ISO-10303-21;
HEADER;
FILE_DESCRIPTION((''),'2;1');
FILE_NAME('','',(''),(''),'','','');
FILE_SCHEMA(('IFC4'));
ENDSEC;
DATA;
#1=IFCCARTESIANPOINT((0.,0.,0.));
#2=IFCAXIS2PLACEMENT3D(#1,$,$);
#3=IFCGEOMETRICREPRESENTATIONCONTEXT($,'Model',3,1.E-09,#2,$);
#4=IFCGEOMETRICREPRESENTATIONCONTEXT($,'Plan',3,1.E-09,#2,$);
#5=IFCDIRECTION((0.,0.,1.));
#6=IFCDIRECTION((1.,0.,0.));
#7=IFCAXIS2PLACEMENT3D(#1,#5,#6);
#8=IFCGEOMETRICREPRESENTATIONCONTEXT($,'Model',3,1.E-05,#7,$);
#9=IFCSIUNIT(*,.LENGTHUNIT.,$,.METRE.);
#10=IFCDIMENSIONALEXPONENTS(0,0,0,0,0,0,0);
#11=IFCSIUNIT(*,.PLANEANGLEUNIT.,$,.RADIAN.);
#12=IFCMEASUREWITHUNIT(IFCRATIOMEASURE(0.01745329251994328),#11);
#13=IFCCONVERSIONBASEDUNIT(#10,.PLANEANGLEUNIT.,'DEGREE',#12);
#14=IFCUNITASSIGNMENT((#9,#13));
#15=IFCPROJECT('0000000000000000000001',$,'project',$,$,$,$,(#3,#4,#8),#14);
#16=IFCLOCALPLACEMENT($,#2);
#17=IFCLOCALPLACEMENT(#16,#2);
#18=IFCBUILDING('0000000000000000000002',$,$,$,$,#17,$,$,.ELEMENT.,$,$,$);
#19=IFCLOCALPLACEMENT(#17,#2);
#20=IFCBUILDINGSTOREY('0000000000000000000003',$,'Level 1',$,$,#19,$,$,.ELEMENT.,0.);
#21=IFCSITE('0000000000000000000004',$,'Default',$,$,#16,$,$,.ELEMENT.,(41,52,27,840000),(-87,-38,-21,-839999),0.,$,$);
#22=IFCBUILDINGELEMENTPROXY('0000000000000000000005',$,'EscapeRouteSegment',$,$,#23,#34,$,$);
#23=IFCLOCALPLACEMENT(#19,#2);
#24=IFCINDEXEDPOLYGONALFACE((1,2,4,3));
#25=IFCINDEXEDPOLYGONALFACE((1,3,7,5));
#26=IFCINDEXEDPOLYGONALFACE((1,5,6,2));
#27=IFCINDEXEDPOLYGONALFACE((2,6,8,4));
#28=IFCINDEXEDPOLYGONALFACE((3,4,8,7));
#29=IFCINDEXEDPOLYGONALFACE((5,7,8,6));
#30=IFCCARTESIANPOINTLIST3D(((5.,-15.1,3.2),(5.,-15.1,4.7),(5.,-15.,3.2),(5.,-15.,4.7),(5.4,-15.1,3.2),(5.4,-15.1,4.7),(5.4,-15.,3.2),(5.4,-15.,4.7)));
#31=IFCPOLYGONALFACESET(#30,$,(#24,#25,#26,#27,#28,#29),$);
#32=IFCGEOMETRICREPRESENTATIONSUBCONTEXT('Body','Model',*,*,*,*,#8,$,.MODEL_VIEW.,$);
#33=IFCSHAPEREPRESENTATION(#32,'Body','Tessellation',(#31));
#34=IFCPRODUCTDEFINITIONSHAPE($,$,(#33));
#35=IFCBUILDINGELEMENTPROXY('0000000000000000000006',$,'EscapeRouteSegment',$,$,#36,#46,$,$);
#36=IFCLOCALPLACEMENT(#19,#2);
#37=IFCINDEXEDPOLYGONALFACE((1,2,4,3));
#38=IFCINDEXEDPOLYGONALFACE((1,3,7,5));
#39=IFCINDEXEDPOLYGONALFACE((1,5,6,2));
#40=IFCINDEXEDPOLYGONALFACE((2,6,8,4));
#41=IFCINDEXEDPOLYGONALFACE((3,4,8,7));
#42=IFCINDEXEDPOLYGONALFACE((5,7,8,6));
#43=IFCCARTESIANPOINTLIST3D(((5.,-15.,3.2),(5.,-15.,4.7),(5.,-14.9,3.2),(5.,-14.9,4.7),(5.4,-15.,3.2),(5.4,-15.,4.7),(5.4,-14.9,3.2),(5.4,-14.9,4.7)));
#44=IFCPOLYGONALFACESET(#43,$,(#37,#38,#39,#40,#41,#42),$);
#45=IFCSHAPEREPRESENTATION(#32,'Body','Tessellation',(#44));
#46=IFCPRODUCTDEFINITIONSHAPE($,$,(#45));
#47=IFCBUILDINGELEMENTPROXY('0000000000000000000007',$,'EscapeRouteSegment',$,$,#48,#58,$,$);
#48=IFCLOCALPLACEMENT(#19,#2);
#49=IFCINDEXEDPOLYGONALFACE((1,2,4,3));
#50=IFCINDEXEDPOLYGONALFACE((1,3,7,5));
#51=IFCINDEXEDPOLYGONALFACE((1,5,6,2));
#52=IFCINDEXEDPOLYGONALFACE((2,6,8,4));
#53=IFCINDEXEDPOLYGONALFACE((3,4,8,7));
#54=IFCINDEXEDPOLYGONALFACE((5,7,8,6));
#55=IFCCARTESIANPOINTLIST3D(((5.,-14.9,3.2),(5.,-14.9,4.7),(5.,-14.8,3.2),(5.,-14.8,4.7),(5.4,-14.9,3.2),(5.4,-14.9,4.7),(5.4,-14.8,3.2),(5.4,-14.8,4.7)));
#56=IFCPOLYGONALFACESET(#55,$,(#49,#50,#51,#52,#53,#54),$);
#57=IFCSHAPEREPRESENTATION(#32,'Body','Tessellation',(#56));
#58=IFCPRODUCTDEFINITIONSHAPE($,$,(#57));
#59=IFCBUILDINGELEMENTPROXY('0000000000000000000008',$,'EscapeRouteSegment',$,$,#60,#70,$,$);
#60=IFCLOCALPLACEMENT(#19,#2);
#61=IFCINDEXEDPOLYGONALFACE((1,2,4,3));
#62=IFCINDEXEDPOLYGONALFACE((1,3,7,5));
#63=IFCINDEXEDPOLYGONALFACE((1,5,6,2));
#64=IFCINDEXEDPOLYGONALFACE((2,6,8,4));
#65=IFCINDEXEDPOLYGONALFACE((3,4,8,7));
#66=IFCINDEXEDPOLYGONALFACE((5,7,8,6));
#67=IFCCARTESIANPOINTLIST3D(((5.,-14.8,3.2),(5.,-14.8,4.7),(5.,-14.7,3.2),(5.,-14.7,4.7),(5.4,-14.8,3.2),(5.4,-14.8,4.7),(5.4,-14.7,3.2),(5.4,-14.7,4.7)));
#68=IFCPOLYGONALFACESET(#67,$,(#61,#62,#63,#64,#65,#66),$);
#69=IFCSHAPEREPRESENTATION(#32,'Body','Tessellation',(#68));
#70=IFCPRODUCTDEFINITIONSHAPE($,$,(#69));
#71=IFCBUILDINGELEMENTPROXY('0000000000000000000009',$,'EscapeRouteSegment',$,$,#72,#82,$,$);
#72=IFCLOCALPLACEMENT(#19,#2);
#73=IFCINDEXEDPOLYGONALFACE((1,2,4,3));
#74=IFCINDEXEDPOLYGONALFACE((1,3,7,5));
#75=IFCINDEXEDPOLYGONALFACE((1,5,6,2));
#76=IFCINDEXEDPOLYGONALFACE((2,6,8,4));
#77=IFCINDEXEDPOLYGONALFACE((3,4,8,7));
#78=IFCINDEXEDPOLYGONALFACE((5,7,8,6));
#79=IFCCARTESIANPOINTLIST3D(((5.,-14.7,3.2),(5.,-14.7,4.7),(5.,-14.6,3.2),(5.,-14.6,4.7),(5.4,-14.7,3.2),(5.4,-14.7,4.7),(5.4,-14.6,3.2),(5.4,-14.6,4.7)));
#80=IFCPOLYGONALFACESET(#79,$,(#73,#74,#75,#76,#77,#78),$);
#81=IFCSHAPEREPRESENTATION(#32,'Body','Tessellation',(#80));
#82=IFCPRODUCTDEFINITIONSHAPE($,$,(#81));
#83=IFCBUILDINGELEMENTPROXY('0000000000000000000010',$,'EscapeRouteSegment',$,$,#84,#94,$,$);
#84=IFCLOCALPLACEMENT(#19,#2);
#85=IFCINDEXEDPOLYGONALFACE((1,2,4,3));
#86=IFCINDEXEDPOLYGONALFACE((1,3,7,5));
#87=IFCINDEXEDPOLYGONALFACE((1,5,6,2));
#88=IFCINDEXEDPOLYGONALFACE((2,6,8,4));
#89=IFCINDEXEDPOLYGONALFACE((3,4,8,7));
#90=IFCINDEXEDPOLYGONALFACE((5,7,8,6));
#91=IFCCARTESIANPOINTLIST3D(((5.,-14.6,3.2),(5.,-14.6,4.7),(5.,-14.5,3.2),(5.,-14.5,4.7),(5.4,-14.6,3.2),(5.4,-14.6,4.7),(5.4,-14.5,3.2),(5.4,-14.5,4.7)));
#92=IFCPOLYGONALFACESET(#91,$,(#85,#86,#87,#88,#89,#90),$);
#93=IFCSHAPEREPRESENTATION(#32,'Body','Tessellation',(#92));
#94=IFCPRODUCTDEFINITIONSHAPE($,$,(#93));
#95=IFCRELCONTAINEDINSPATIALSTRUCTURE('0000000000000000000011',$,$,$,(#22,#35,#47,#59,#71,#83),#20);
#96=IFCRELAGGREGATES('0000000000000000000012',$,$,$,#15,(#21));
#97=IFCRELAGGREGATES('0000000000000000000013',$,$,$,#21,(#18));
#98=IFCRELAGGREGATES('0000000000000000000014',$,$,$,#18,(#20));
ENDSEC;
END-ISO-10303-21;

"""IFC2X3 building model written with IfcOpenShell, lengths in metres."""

from ifc_helpers import new_model, entity, si_unit, converted_unit, frame, origin, origin_with_axes, place, context, subcontext, project, spatial, polyline, outline, extrude, element, save


model = new_model("IFC2X3")

# Units and contexts
model_context_1 = context("Model", 3, precision=1e-09, world=origin())
plan_context = context("Plan", 3, precision=1e-09, world=origin())
model_context_2 = context("Model", 3, precision=1e-05, world=origin_with_axes())
body_context = subcontext(model_context_2, "Body", "Model", "MODEL_VIEW")
ifc_project = project(units=[si_unit("LENGTHUNIT", "METRE"), converted_unit("PLANEANGLEUNIT", "DEGREE", entity("IfcRatioMeasure", 0.01745329251994328), si_unit("PLANEANGLEUNIT", "RADIAN"), dimensions=[0, 0, 0, 0, 0, 0, 0])], contexts=[model_context_1, plan_context, model_context_2])

# Site, building, storey
site_placement = place(None, origin())
site = spatial("IfcSite", under=ifc_project, at=site_placement, Name="Default", CompositionType="ELEMENT", RefLatitude=(41, 52, 27, 840000), RefLongitude=(-87, -38, -21, -839999), RefElevation=0.0)
building_placement = place(site_placement, origin())
building = spatial("IfcBuilding", under=site, at=building_placement, CompositionType="ELEMENT")
storey_placement = place(building_placement, origin())
storey = spatial("IfcBuildingStorey", under=building, at=storey_placement, Name="Level 1", CompositionType="ELEMENT", Elevation=0.0)

# Building element proxies
for number, where, z_axis, x_axis, name in (
    (1, (5.2, -15.1, 3.2), (0.0, 0.0, 1.0), (0.0, 1.0, 0.0), "EscapeRouteSegment"),
    (2, (5.2, -15.0, 3.2), (0.0, 0.0, 1.0), (0.0, 1.0, 0.0), "EscapeRouteSegment"),
):
    element("IfcBuildingElementProxy", number, at=place(storey_placement, frame(where, z_axis=z_axis, x_axis=x_axis)), inside=storey, Name=name, context=body_context, shape_type="SweptSolid", body=[
        extrude(outline(polyline([(0.0, -0.2), (0.0, 0.2), (0.1, 0.2), (0.1, -0.2), (0.0, -0.2)])), origin_with_axes(), (0.0, 0.0, 1.0), 1.5),
    ])
proxy_1_placement = place(storey_placement, frame((5.2, -14.9, 3.2), z_axis=(0.0, 0.0, 1.0), x_axis=(0.0, 1.0, 0.0)))
element("IfcBuildingElementProxy", 3, at=proxy_1_placement, inside=storey, Name="EscapeRouteSegment", context=body_context, shape_type="SweptSolid", body=[
    extrude(outline(polyline([(0.0, -0.2), (0.0, 0.2), (0.1, 0.2), (0.1, -0.2), (0.0, -0.2)])), origin_with_axes(), (0.0, 0.0, 1.0), 1.5),
])
proxy_2_placement = place(storey_placement, frame((5.2, -14.8, 3.2), z_axis=(0.0, 0.0, 1.0), x_axis=(0.0, 1.0, 0.0)))
element("IfcBuildingElementProxy", 4, at=proxy_2_placement, inside=storey, Name="EscapeRouteSegment", context=body_context, shape_type="SweptSolid", body=[
    extrude(outline(polyline([(0.0, -0.2), (0.0, 0.2), (0.1, 0.2), (0.1, -0.2), (0.0, -0.2)])), origin_with_axes(), (0.0, 0.0, 1.0), 1.5),
])
proxy_3_placement = place(storey_placement, frame((5.2, -14.7, 3.2), z_axis=(0.0, 0.0, 1.0), x_axis=(0.0, 1.0, 0.0)))
element("IfcBuildingElementProxy", 5, at=proxy_3_placement, inside=storey, Name="EscapeRouteSegment", context=body_context, shape_type="SweptSolid", body=[
    extrude(outline(polyline([(0.0, -0.2), (0.0, 0.2), (0.1, 0.2), (0.1, -0.2), (0.0, -0.2)])), origin_with_axes(), (0.0, 0.0, 1.0), 1.5),
])
for number, where, z_axis, x_axis, name in (
    (6, (5.2, -14.6, 3.2), (0.0, 0.0, 1.0), (0.0, 1.0, 0.0), "EscapeRouteSegment"),
):
    element("IfcBuildingElementProxy", number, at=place(storey_placement, frame(where, z_axis=z_axis, x_axis=x_axis)), inside=storey, Name=name, context=body_context, shape_type="SweptSolid", body=[
        extrude(outline(polyline([(0.0, -0.2), (0.0, 0.2), (0.1, 0.2), (0.1, -0.2), (0.0, -0.2)])), origin_with_axes(), (0.0, 0.0, 1.0), 1.5),
    ])

save(model, "model.ifc")
